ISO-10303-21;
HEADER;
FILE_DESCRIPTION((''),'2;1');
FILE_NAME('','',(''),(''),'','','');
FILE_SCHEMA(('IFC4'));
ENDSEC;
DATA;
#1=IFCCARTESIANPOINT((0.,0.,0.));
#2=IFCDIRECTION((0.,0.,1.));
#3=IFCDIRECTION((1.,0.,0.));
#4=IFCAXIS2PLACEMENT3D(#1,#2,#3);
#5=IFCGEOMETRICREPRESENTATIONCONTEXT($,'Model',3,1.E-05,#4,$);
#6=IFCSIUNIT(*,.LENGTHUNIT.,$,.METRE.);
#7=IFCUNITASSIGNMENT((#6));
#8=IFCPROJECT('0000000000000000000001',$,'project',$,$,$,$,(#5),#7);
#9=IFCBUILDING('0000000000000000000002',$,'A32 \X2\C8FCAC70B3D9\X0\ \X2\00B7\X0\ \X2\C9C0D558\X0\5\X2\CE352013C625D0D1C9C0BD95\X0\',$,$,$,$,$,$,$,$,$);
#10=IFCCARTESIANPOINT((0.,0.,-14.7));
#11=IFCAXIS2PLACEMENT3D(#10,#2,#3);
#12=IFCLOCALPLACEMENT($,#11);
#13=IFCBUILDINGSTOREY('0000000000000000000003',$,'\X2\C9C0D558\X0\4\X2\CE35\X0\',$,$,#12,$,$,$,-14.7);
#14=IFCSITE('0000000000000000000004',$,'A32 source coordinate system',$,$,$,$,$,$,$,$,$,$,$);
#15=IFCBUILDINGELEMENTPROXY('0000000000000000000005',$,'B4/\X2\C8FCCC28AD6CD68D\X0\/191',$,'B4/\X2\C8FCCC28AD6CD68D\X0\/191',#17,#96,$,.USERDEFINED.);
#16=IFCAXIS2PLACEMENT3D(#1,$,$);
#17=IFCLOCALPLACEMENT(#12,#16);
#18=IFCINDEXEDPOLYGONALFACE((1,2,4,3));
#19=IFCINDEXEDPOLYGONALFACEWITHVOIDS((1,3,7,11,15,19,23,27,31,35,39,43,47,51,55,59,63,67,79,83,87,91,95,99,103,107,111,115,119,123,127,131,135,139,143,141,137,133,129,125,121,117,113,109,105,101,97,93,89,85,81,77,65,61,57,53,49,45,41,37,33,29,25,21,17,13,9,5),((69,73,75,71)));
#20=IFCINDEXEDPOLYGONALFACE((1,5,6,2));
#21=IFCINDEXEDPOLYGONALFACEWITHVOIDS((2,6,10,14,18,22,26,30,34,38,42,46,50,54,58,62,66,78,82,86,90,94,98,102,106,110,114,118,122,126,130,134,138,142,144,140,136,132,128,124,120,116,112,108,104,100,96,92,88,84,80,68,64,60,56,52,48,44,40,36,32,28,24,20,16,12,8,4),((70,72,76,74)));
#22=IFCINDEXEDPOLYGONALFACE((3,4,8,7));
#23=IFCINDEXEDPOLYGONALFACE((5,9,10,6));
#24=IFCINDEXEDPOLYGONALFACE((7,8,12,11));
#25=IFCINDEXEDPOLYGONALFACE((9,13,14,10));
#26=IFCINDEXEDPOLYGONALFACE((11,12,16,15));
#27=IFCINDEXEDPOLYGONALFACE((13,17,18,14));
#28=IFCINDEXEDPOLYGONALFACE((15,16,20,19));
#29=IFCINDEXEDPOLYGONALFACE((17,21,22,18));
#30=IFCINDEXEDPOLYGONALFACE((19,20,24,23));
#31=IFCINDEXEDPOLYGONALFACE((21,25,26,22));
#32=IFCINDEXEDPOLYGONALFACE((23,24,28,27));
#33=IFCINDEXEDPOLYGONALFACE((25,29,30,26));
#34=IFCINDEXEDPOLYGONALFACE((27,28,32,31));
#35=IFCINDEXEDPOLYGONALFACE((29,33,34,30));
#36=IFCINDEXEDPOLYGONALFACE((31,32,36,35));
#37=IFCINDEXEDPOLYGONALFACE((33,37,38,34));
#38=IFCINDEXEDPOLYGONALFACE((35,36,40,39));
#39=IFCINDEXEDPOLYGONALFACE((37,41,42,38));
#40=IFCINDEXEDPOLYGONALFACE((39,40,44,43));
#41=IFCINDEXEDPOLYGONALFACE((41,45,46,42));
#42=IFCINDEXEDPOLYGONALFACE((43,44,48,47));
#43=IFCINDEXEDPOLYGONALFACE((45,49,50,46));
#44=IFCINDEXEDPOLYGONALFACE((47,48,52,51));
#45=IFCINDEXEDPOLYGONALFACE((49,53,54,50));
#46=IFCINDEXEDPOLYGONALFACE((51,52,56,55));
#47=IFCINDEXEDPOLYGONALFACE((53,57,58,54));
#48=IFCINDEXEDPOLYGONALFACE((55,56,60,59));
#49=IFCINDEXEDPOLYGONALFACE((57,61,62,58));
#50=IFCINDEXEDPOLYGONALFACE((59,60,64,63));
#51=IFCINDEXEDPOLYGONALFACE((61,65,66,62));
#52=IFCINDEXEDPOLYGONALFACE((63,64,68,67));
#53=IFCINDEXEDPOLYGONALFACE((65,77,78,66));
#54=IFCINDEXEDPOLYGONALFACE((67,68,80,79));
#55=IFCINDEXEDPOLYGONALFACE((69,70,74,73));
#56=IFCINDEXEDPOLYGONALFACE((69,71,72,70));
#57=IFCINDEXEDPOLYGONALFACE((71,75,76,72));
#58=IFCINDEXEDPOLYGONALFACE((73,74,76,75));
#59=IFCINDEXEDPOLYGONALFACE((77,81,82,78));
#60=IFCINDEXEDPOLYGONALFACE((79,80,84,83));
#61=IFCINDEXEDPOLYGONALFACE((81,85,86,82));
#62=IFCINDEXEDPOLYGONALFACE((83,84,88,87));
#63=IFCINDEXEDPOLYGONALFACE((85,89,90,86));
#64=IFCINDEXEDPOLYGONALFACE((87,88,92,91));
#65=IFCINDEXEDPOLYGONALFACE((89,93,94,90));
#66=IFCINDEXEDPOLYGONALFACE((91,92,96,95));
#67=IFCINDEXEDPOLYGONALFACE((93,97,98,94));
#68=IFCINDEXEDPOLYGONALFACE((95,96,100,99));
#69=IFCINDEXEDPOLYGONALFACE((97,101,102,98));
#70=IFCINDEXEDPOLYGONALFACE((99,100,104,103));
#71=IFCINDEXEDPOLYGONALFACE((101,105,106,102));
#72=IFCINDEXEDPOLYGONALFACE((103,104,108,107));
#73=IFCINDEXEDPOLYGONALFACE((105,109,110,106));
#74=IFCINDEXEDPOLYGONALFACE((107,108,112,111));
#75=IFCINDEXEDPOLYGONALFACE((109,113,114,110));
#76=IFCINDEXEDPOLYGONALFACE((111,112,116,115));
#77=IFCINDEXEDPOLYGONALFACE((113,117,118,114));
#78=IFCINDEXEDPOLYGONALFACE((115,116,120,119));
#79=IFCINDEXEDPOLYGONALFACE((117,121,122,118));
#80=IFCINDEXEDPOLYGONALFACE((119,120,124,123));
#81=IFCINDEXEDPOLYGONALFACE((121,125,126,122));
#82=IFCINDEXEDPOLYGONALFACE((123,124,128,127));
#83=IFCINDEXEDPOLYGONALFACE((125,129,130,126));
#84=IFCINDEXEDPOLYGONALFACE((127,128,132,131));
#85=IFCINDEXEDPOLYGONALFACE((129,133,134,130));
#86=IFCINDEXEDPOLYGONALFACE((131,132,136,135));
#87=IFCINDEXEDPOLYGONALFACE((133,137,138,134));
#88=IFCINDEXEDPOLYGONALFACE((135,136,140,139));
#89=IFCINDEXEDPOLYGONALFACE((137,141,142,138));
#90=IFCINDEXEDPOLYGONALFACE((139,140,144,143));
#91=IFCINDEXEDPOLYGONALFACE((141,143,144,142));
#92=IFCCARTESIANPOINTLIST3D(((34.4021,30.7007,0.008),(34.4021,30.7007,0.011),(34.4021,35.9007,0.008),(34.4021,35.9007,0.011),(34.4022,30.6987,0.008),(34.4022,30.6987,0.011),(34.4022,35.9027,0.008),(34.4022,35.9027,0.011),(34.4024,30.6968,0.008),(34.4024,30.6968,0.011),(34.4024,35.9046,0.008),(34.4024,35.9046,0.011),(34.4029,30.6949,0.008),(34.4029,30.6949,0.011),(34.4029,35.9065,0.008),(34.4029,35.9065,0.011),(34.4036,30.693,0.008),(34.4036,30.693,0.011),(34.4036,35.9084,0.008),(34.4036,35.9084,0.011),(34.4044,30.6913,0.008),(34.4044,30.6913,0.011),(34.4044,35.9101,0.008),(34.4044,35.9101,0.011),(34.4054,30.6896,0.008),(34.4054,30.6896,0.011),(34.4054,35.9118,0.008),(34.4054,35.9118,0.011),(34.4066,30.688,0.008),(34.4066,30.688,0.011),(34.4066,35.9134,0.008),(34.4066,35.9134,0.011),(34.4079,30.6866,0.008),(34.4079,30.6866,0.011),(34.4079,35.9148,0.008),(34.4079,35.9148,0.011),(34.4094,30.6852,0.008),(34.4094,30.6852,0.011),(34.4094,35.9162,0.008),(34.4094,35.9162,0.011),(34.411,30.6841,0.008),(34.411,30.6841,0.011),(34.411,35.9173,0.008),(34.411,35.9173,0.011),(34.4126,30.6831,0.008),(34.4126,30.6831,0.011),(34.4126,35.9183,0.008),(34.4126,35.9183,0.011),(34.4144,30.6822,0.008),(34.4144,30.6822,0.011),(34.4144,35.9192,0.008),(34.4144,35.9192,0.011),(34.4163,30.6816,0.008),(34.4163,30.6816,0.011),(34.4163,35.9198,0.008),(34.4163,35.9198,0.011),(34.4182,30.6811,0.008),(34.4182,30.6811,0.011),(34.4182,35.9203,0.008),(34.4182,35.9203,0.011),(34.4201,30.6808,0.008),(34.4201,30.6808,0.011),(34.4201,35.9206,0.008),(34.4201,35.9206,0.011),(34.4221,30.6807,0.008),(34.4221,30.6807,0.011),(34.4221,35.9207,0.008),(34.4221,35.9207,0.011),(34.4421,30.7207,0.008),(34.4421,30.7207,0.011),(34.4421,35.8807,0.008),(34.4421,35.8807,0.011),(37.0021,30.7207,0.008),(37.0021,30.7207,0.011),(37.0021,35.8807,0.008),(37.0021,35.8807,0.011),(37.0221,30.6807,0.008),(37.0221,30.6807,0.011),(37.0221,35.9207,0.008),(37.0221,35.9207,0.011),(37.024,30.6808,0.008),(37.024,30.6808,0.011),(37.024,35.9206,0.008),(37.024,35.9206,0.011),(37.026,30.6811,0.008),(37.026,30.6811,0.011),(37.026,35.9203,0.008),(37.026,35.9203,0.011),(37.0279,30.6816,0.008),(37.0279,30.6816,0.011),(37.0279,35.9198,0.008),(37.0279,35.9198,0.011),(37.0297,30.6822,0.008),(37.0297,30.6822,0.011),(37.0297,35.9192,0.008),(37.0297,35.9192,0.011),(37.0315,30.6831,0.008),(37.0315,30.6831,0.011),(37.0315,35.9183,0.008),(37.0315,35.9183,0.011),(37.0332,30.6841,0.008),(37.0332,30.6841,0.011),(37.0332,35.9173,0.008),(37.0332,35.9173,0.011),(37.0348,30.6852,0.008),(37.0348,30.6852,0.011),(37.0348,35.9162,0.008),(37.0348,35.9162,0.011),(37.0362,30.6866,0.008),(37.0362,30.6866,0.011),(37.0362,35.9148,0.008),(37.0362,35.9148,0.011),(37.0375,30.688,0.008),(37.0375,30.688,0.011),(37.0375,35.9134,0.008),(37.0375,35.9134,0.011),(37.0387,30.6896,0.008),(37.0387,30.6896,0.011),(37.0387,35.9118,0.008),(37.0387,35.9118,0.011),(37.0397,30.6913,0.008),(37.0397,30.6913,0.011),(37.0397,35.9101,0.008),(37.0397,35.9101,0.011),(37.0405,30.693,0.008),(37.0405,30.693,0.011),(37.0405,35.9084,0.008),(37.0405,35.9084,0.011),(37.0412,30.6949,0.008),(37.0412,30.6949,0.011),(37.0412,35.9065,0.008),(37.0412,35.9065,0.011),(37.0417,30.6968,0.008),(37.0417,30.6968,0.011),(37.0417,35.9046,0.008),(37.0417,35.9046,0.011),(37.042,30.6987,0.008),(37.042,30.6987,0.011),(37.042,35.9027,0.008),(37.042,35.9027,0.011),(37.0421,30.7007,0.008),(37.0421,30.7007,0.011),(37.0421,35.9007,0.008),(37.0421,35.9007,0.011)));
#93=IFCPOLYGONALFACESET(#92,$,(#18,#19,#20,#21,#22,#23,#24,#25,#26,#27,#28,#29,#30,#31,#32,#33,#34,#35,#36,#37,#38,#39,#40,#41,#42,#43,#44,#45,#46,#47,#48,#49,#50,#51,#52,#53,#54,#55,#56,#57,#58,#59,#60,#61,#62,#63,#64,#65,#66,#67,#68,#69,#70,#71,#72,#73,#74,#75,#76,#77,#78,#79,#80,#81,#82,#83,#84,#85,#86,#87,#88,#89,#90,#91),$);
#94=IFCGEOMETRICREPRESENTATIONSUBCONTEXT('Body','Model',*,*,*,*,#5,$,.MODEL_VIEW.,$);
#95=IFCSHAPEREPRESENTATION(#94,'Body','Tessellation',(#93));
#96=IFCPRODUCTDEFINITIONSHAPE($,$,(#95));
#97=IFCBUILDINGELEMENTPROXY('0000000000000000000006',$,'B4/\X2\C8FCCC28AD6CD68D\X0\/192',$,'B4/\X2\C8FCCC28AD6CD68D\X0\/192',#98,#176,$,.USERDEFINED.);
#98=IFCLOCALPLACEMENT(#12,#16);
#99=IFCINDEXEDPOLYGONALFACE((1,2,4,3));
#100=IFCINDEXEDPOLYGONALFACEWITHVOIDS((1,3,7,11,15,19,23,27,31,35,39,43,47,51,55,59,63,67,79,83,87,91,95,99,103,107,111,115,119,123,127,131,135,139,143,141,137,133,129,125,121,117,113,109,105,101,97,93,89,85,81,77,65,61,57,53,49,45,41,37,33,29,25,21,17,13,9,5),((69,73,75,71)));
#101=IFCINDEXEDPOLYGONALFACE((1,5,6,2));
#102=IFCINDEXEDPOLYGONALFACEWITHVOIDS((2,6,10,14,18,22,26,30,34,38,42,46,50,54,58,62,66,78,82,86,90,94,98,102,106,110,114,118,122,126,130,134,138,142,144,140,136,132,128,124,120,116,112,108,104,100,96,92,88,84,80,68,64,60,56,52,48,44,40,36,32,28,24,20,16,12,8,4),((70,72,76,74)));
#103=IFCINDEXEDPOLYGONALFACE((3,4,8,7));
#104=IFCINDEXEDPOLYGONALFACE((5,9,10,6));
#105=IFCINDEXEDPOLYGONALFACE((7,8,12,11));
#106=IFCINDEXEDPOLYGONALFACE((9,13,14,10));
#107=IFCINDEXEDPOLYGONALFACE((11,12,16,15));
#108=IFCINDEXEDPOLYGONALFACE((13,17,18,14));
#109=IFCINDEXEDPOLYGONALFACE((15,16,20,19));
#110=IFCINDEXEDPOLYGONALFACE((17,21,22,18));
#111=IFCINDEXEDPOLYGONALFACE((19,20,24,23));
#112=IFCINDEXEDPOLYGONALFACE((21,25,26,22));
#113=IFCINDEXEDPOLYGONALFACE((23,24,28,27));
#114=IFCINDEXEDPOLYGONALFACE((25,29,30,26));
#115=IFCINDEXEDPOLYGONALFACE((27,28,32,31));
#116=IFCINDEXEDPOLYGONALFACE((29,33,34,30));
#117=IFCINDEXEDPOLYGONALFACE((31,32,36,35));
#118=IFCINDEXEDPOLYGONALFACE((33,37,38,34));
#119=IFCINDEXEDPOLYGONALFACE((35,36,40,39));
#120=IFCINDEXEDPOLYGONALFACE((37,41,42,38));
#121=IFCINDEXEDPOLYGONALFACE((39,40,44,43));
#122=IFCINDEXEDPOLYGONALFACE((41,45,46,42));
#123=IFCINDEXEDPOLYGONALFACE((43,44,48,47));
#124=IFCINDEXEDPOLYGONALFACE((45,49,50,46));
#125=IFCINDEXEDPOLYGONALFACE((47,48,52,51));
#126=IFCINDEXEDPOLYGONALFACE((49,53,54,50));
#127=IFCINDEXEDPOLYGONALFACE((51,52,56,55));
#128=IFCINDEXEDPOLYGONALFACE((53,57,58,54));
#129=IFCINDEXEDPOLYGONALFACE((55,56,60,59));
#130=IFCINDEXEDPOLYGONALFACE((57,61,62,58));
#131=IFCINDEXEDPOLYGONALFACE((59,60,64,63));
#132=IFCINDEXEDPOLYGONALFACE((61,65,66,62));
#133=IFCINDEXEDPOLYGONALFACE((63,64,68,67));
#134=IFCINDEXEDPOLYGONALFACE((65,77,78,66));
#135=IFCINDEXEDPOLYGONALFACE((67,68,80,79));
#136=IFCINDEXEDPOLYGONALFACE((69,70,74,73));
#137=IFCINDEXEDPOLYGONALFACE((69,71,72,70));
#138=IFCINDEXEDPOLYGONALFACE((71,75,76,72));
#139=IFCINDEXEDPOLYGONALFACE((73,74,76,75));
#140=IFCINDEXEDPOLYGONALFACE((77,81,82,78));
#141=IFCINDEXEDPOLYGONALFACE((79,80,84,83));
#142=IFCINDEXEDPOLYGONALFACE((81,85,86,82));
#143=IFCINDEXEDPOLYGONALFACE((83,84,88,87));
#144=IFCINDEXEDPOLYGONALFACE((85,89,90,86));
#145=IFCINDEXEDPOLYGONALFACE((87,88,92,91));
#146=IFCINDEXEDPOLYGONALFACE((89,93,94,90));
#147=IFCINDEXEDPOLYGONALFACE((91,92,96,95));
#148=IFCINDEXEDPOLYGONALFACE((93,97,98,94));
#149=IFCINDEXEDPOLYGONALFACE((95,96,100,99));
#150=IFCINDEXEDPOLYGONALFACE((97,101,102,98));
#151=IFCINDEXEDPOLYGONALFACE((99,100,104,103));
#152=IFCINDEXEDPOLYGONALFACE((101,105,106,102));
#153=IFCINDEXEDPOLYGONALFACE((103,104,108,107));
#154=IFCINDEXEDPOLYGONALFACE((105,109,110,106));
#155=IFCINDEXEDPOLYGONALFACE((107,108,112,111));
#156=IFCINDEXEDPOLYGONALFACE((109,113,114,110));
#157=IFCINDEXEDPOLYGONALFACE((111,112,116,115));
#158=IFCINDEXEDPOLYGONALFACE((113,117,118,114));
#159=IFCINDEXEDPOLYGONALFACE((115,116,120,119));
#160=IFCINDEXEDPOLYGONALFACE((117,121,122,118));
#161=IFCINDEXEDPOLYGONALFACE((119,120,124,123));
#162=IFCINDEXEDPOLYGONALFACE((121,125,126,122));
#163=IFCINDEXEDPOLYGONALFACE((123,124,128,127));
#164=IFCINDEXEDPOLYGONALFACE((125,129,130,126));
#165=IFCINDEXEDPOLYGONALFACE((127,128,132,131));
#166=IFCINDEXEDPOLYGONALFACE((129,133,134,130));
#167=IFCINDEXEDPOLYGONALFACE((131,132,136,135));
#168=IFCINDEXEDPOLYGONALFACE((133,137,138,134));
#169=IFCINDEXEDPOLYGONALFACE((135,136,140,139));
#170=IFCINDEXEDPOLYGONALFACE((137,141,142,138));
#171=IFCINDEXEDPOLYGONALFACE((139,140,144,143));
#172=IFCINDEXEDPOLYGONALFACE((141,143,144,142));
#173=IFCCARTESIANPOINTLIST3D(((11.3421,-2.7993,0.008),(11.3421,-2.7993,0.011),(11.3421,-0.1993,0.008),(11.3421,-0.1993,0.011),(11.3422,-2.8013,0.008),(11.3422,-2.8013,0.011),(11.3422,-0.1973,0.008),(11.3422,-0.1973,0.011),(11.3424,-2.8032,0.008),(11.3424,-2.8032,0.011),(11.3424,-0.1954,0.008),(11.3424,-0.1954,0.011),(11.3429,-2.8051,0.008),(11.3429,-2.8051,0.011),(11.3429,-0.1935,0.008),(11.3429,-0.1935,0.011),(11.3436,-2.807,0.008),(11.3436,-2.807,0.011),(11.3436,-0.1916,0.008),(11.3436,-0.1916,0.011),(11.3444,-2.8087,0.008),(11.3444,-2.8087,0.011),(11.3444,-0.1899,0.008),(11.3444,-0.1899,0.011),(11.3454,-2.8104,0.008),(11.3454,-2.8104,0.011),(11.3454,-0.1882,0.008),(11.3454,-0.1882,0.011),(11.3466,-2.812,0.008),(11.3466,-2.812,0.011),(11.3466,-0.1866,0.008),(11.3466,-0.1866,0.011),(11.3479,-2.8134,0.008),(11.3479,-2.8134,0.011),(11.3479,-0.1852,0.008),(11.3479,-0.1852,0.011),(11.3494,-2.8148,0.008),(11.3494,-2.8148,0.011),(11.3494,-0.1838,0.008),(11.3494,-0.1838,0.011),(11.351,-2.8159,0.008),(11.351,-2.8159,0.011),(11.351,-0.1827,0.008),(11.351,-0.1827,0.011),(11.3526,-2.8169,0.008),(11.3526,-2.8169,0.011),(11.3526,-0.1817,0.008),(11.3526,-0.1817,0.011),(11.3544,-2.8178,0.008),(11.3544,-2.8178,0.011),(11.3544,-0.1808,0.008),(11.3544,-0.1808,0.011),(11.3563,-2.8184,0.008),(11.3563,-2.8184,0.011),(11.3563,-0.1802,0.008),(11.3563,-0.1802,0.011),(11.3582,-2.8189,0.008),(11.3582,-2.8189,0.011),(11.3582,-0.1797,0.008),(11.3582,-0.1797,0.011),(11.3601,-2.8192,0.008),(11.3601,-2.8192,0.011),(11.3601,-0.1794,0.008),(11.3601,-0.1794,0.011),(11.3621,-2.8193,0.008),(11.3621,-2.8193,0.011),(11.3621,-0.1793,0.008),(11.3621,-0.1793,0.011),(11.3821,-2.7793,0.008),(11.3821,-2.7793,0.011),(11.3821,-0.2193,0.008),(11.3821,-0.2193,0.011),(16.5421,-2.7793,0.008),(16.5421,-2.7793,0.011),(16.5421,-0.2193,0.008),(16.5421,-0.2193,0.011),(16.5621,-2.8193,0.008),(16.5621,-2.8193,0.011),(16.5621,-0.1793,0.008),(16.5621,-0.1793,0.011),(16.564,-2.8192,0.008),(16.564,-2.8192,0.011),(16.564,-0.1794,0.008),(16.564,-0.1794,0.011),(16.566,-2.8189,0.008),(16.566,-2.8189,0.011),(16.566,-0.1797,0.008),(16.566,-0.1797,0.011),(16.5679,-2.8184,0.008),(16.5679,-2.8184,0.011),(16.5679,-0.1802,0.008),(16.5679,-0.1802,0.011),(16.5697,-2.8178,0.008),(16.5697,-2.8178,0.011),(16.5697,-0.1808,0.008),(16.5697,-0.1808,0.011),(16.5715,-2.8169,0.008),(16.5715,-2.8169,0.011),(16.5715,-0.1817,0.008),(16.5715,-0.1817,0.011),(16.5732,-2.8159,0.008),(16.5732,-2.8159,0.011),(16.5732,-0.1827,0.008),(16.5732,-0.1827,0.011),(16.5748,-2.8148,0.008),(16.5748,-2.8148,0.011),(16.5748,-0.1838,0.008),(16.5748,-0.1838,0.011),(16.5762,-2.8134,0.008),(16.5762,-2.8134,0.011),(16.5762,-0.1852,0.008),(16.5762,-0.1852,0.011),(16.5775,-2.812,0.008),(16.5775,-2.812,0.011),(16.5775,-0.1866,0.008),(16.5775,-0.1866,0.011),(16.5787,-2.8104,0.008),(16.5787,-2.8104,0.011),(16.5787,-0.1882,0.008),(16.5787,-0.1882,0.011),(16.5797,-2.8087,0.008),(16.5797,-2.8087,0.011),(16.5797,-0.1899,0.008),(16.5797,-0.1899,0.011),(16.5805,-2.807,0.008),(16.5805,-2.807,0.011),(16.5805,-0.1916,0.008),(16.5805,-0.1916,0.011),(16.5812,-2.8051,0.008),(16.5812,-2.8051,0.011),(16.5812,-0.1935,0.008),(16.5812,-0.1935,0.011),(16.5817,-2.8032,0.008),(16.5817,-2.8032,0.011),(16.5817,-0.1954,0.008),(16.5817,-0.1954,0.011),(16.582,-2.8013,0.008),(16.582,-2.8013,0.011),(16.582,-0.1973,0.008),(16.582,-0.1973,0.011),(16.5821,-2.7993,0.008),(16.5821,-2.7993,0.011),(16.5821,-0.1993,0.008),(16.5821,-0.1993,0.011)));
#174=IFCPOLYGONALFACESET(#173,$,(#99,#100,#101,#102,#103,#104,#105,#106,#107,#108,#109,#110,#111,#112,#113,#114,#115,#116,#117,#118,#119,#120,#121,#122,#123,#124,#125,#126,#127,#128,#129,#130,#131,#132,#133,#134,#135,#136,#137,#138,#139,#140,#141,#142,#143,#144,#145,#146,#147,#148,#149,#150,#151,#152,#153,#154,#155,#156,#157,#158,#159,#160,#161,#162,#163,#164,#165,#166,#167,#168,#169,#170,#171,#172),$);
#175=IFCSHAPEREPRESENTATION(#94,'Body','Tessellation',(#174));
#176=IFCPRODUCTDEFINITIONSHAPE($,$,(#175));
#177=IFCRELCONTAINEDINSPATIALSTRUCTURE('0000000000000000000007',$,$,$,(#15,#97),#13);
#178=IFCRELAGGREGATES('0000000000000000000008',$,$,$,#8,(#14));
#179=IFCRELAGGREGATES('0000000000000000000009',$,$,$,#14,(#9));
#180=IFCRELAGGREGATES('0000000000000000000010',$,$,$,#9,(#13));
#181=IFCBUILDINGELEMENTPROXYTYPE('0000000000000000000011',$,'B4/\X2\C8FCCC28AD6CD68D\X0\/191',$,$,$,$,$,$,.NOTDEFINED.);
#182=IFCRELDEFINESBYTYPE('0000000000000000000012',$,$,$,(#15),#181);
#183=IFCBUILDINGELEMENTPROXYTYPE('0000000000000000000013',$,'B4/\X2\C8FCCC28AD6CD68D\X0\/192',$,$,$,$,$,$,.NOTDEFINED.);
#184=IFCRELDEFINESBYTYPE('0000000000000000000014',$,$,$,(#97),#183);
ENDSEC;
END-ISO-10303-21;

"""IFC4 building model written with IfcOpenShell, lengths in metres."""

from ifc_helpers import new_model, si_unit, frame, origin, origin_with_axes, place, context, subcontext, project, spatial, polyline, outline, extrude, source, transform, mapped, type_object, type_shapes, element, save


model = new_model("IFC4")

# Units and contexts
model_context = context("Model", 3, precision=1e-05, world=origin_with_axes())
body_context = subcontext(model_context, "Body", "Model", "MODEL_VIEW")
ifc_project = project(units=[si_unit("LENGTHUNIT", "METRE")], contexts=[model_context])

# Site, building, storey
site = spatial("IfcSite", under=ifc_project, Name="A32 source coordinate system")
building = spatial("IfcBuilding", under=site, Name="A32 주거동 · 지하5층–옥탑지붕")
storey_placement = place(None, frame((0.0, 0.0, -14.7), z_axis=(0.0, 0.0, 1.0), x_axis=(1.0, 0.0, 0.0)))
storey = spatial("IfcBuildingStorey", under=building, at=storey_placement, Name="지하4층", Elevation=-14.7)

# Building element proxies
building_element_proxy_type_1 = type_object("IfcBuildingElementProxyType", Name="B4/주차구획/191", PredefinedType="NOTDEFINED")
shared_shape_1 = source(origin(), body_context, "Body", "SweptSolid", [
    extrude(outline(polyline([(34.4021, 35.9007), (34.4022, 35.9027), (34.4024, 35.9046), (34.4029, 35.9065), (34.4036, 35.9084), (34.4044, 35.9101), (34.4054, 35.9118), (34.4066, 35.9134), (34.4079, 35.9148), (34.4094, 35.9162), (34.411, 35.9173), (34.4126, 35.9183), (34.4144, 35.9192), (34.4163, 35.9198), (34.4182, 35.9203), (34.4201, 35.9206), (34.4221, 35.9207), (37.0221, 35.9207), (37.024, 35.9206), (37.026, 35.9203), (37.0279, 35.9198), (37.0297, 35.9192), (37.0315, 35.9183), (37.0332, 35.9173), (37.0348, 35.9162), (37.0362, 35.9148), (37.0375, 35.9134), (37.0387, 35.9118), (37.0397, 35.9101), (37.0405, 35.9084), (37.0412, 35.9065), (37.0417, 35.9046), (37.042, 35.9027), (37.0421, 35.9007), (37.0421, 30.7007), (37.042, 30.6987), (37.0417, 30.6968), (37.0412, 30.6949), (37.0405, 30.693), (37.0397, 30.6913), (37.0387, 30.6896), (37.0375, 30.688), (37.0362, 30.6866), (37.0348, 30.6852), (37.0332, 30.6841), (37.0315, 30.6831), (37.0297, 30.6822), (37.0279, 30.6816), (37.026, 30.6811), (37.024, 30.6808), (37.0221, 30.6807), (34.4221, 30.6807), (34.4201, 30.6808), (34.4182, 30.6811), (34.4163, 30.6816), (34.4144, 30.6822), (34.4126, 30.6831), (34.411, 30.6841), (34.4094, 30.6852), (34.4079, 30.6866), (34.4066, 30.688), (34.4054, 30.6896), (34.4044, 30.6913), (34.4036, 30.693), (34.4029, 30.6949), (34.4024, 30.6968), (34.4022, 30.6987), (34.4021, 30.7007), (34.4021, 35.9007)]), holes=[polyline([(34.4421, 35.8807), (34.4421, 30.7207), (37.0021, 30.7207), (37.0021, 35.8807), (34.4421, 35.8807)])]), frame((0.0, 0.0, 0.008)), (0.0, 0.0, 1.0), 0.003),
])
type_shapes(building_element_proxy_type_1, [shared_shape_1])
proxy_1_placement = place(storey_placement, origin_with_axes())
element("IfcBuildingElementProxy", 1, at=proxy_1_placement, inside=storey, type_object=building_element_proxy_type_1, Name="B4/주차구획/191", ObjectType="B4/주차구획/191", PredefinedType="USERDEFINED", context=body_context, shape_type="MappedRepresentation", body=[
    mapped(shared_shape_1, transform((0.0, 0.0, 0.0), scale=1.0)),
])
building_element_proxy_type_2 = type_object("IfcBuildingElementProxyType", Name="B4/주차구획/192", PredefinedType="NOTDEFINED")
shared_shape_2 = source(origin(), body_context, "Body", "SweptSolid", [
    extrude(outline(polyline([(16.5621, -0.1793), (16.564, -0.1794), (16.566, -0.1797), (16.5679, -0.1802), (16.5697, -0.1808), (16.5715, -0.1817), (16.5732, -0.1827), (16.5748, -0.1838), (16.5762, -0.1852), (16.5775, -0.1866), (16.5787, -0.1882), (16.5797, -0.1899), (16.5805, -0.1916), (16.5812, -0.1935), (16.5817, -0.1954), (16.582, -0.1973), (16.5821, -0.1993), (16.5821, -2.7993), (16.582, -2.8013), (16.5817, -2.8032), (16.5812, -2.8051), (16.5805, -2.807), (16.5797, -2.8087), (16.5787, -2.8104), (16.5775, -2.812), (16.5762, -2.8134), (16.5748, -2.8148), (16.5732, -2.8159), (16.5715, -2.8169), (16.5697, -2.8178), (16.5679, -2.8184), (16.566, -2.8189), (16.564, -2.8192), (16.5621, -2.8193), (11.3621, -2.8193), (11.3601, -2.8192), (11.3582, -2.8189), (11.3563, -2.8184), (11.3544, -2.8178), (11.3526, -2.8169), (11.351, -2.8159), (11.3494, -2.8148), (11.3479, -2.8134), (11.3466, -2.812), (11.3454, -2.8104), (11.3444, -2.8087), (11.3436, -2.807), (11.3429, -2.8051), (11.3424, -2.8032), (11.3422, -2.8013), (11.3421, -2.7993), (11.3421, -0.1993), (11.3422, -0.1973), (11.3424, -0.1954), (11.3429, -0.1935), (11.3436, -0.1916), (11.3444, -0.1899), (11.3454, -0.1882), (11.3466, -0.1866), (11.3479, -0.1852), (11.3494, -0.1838), (11.351, -0.1827), (11.3526, -0.1817), (11.3544, -0.1808), (11.3563, -0.1802), (11.3582, -0.1797), (11.3601, -0.1794), (11.3621, -0.1793), (16.5621, -0.1793)]), holes=[polyline([(16.5421, -0.2193), (11.3821, -0.2193), (11.3821, -2.7793), (16.5421, -2.7793), (16.5421, -0.2193)])]), frame((0.0, 0.0, 0.008)), (0.0, 0.0, 1.0), 0.003),
])
type_shapes(building_element_proxy_type_2, [shared_shape_2])
proxy_2_placement = place(storey_placement, origin_with_axes())
element("IfcBuildingElementProxy", 2, at=proxy_2_placement, inside=storey, type_object=building_element_proxy_type_2, Name="B4/주차구획/192", ObjectType="B4/주차구획/192", PredefinedType="USERDEFINED", context=body_context, shape_type="MappedRepresentation", body=[
    mapped(shared_shape_2, transform((0.0, 0.0, 0.0), scale=1.0)),
])

save(model, "model.ifc")
